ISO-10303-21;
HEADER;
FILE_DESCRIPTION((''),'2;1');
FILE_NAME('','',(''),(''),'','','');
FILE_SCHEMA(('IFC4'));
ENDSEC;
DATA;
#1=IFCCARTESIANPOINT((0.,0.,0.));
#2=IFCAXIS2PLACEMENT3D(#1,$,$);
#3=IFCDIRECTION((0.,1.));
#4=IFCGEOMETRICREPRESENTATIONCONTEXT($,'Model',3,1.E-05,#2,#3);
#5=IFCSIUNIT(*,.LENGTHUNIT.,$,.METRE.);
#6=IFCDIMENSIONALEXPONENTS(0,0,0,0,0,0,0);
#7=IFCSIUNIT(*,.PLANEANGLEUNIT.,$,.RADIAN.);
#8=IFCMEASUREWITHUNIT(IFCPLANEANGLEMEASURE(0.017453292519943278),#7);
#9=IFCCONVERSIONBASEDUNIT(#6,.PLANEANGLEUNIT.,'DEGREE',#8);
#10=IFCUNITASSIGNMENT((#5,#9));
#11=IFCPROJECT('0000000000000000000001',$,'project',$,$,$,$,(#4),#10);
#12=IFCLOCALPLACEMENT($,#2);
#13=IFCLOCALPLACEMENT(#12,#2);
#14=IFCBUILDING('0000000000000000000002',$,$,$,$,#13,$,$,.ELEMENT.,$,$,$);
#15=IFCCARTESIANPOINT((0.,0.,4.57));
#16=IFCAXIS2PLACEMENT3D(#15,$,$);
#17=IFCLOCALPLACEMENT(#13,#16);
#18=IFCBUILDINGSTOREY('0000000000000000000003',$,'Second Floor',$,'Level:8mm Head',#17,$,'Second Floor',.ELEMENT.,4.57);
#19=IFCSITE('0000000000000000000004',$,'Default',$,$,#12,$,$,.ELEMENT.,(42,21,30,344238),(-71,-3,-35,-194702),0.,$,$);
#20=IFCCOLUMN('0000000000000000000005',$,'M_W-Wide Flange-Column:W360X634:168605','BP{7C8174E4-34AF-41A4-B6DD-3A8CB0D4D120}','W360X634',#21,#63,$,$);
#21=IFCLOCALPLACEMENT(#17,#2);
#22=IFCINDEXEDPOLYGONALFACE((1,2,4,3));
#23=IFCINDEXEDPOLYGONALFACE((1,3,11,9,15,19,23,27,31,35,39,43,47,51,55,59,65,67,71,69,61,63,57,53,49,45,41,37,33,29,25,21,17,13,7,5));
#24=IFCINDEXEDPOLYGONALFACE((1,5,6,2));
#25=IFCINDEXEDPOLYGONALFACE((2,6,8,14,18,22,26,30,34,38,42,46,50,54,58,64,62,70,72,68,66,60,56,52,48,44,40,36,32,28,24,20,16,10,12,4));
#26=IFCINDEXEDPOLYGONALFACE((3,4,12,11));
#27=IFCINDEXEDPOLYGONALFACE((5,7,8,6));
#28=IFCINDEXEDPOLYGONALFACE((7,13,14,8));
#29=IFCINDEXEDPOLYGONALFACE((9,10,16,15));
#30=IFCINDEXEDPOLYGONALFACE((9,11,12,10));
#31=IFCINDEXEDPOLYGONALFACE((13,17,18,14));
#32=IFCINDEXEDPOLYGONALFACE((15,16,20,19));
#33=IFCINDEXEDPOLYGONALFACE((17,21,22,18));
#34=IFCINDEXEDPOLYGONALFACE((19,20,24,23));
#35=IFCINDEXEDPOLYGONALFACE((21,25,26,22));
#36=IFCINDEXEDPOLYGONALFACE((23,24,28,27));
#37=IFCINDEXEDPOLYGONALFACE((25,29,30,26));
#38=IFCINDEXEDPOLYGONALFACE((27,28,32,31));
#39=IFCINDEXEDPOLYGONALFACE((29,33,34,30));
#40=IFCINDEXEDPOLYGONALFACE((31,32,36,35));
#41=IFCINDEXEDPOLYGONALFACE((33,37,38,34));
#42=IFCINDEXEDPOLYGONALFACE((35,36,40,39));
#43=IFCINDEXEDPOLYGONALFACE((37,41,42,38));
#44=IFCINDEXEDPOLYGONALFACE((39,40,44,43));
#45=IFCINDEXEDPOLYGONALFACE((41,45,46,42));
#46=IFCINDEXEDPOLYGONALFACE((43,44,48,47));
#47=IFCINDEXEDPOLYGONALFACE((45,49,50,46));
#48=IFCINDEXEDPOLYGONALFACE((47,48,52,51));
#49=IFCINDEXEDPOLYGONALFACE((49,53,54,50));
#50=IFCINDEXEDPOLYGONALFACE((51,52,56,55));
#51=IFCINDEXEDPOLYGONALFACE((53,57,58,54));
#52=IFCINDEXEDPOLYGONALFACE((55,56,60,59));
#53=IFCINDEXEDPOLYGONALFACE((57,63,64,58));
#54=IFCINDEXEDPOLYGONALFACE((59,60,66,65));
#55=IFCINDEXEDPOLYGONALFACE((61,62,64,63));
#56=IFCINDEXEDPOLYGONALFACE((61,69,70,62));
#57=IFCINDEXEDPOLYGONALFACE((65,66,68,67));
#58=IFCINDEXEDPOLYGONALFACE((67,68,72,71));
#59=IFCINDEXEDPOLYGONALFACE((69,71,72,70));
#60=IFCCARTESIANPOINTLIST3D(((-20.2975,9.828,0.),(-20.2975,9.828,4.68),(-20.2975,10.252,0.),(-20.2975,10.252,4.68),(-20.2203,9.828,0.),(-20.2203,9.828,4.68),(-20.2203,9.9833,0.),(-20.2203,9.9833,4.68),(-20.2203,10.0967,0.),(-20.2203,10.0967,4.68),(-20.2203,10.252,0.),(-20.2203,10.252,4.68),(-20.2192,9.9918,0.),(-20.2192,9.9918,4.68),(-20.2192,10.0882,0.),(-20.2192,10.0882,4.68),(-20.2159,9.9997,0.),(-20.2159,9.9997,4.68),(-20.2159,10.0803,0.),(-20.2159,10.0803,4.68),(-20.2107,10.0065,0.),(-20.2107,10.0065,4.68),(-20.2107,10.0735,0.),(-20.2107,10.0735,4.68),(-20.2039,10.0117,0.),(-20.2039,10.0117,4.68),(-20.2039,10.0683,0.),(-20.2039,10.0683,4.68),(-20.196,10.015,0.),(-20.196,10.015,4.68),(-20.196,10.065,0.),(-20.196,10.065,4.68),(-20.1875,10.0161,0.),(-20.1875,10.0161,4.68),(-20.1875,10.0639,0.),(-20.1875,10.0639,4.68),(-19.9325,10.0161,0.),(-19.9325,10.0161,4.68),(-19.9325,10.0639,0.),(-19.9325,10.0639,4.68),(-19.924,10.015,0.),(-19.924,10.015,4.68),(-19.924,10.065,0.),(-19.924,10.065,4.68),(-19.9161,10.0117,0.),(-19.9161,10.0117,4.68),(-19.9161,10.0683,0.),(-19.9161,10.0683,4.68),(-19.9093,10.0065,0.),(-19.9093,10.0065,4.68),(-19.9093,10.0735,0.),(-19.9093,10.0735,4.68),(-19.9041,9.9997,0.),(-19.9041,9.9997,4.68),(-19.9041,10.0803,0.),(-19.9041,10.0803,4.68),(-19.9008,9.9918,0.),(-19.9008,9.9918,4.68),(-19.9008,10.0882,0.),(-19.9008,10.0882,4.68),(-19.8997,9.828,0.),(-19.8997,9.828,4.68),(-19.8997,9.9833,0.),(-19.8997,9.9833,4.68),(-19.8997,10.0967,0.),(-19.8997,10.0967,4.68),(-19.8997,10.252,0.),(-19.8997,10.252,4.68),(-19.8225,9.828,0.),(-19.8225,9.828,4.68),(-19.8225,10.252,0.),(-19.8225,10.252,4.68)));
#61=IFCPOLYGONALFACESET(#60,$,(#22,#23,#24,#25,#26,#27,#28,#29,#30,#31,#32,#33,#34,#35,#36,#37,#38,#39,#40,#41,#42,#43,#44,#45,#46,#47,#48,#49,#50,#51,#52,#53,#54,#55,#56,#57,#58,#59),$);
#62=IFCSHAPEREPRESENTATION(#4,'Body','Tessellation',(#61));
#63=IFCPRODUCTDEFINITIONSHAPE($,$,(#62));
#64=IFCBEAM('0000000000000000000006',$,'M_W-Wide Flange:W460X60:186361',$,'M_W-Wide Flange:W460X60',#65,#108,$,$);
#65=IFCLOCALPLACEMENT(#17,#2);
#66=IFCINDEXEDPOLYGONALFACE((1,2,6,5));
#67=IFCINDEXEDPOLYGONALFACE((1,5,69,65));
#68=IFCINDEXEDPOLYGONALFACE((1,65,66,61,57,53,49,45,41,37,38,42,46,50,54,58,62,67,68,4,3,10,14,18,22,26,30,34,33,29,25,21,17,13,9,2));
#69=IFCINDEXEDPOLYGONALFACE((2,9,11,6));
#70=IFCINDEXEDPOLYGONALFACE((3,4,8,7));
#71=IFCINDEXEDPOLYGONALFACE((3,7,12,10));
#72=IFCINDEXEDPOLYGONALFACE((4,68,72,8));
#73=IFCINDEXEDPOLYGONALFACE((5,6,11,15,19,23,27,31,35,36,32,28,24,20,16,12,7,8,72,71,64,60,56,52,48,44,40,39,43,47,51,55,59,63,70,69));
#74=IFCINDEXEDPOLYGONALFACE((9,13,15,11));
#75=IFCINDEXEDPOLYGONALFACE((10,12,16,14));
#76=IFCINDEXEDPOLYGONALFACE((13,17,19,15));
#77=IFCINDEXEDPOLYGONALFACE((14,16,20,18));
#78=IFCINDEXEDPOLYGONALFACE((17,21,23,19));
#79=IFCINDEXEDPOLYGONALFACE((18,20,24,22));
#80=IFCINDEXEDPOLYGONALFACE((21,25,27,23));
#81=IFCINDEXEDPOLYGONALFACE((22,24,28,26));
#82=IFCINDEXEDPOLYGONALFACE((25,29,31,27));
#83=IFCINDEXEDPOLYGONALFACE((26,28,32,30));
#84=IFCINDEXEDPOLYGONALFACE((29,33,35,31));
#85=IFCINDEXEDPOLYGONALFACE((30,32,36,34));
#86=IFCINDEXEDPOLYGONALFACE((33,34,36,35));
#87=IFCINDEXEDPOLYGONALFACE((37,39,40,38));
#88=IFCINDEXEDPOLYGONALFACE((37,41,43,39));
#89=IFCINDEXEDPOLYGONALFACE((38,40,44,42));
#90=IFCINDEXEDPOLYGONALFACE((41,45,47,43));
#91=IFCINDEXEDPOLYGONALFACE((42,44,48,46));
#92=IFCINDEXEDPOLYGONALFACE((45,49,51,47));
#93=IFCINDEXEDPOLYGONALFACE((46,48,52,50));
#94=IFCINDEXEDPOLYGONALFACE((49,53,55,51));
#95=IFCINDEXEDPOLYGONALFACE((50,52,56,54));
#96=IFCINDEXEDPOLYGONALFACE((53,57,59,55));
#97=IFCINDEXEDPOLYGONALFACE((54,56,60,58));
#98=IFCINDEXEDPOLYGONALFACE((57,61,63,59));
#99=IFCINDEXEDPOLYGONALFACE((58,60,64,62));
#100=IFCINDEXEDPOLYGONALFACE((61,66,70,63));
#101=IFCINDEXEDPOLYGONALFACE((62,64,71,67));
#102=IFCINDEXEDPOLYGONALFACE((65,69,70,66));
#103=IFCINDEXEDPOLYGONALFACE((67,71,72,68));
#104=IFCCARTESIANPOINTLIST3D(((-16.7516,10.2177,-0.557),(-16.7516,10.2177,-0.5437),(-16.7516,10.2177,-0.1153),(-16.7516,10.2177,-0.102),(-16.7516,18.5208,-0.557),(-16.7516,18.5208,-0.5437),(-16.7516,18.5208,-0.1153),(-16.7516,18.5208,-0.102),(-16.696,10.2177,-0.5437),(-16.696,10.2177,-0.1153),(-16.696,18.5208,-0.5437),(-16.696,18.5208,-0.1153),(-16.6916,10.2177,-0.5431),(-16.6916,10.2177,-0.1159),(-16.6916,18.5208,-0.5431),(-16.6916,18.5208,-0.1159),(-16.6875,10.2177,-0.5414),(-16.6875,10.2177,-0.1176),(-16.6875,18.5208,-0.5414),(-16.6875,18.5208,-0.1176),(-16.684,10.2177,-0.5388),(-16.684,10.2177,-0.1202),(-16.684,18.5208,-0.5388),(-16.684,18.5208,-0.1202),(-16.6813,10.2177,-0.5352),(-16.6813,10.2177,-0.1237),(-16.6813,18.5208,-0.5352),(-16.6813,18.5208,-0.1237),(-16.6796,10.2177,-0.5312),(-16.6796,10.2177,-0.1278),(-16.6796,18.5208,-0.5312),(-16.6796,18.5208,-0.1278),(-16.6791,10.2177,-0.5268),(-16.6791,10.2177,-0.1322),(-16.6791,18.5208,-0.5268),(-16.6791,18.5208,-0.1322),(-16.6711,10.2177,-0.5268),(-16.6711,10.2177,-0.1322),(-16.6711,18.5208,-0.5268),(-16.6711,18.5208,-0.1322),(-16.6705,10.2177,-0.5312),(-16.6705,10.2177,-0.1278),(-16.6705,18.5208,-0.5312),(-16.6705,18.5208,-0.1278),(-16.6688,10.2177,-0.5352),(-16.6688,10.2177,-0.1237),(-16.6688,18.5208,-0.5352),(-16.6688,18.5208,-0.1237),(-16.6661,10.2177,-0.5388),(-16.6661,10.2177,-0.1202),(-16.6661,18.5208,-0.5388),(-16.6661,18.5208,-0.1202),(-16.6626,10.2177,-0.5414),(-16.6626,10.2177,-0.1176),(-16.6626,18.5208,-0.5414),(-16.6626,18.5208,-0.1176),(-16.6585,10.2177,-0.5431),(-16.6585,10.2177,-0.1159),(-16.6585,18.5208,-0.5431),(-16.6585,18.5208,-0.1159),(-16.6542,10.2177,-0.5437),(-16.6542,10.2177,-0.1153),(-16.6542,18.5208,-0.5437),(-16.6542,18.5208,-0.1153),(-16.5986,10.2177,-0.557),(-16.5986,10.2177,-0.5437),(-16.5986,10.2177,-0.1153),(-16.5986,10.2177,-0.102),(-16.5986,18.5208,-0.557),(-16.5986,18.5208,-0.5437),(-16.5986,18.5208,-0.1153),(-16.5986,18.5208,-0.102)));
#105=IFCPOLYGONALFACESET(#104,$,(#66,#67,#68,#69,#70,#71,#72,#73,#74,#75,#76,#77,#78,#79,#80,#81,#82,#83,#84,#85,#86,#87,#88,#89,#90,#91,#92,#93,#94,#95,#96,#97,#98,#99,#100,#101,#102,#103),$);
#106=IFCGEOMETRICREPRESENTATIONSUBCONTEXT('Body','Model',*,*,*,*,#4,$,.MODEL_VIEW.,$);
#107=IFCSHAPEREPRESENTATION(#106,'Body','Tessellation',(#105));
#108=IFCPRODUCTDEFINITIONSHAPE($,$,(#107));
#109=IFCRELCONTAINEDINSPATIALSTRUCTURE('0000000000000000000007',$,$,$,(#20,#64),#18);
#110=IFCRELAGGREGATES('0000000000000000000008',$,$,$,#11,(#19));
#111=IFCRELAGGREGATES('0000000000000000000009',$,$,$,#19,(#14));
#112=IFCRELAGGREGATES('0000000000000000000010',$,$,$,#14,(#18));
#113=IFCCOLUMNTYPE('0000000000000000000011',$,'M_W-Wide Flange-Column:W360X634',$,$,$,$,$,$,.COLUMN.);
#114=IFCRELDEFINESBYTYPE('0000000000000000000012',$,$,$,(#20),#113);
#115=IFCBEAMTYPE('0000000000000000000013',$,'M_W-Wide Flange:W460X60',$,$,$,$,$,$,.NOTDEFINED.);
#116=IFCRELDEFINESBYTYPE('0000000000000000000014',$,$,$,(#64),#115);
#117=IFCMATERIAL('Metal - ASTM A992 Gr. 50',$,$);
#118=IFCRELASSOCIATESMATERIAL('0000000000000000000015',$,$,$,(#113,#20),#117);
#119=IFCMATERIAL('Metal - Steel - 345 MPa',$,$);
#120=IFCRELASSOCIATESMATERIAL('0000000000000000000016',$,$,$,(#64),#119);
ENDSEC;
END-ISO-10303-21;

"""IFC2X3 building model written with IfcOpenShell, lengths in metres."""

from ifc_helpers import new_model, entity, si_unit, converted_unit, direction, frame, frame_2d, origin, origin_2d, place, context, subcontext, project, spatial, i_section, extrude, material, type_object, element, save


model = new_model("IFC2X3")

# Units and contexts
model_context = context("Model", 3, precision=1e-05, world=origin(), true_north=direction((0.0, 1.0)))
body_context = subcontext(model_context, "Body", "Model", "MODEL_VIEW")
ifc_project = project(units=[si_unit("LENGTHUNIT", "METRE"), converted_unit("PLANEANGLEUNIT", "DEGREE", entity("IfcPlaneAngleMeasure", 0.017453292519943278), si_unit("PLANEANGLEUNIT", "RADIAN"), dimensions=[0, 0, 0, 0, 0, 0, 0])], contexts=[model_context])

# Site, building, storey
site_placement = place(None, origin())
site = spatial("IfcSite", under=ifc_project, at=site_placement, Name="Default", CompositionType="ELEMENT", RefLatitude=(42, 21, 30, 344238), RefLongitude=(-71, -3, -35, -194702), RefElevation=0.0)
building_placement = place(site_placement, origin())
building = spatial("IfcBuilding", under=site, at=building_placement, CompositionType="ELEMENT")
storey_placement = place(building_placement, frame((0.0, 0.0, 4.57)))
storey = spatial("IfcBuildingStorey", under=building, at=storey_placement, Name="Second Floor", ObjectType="Level:8mm Head", LongName="Second Floor", CompositionType="ELEMENT", Elevation=4.57)

# Column
ifc_material_1 = material(Name="Metal - ASTM A992 Gr. 50")
column_type = type_object("IfcColumnType", Name="M_W-Wide Flange-Column:W360X634", PredefinedType="COLUMN", material=ifc_material_1)
column_placement = place(storey_placement, frame((-20.06, 10.04, 4.68), z_axis=(0.0, 0.0, 1.0), x_axis=(0.0, -1.0, 0.0)))
element("IfcColumn", 1, at=column_placement, inside=storey, type_object=column_type, material=ifc_material_1, Name="M_W-Wide Flange-Column:W360X634:168605", Description="BP{7C8174E4-34AF-41A4-B6DD-3A8CB0D4D120}", ObjectType="W360X634", context=model_context, shape_type="SweptSolid", body=[
    extrude(i_section(OverallWidth=0.424, OverallDepth=0.475, WebThickness=0.0478, FlangeThickness=0.0772, FilletRadius=0.0328, at=origin_2d()), origin(), (0.0, 0.0, -1.0), 4.68),
])

# Beam
ifc_material_2 = material(Name="Metal - Steel - 345 MPa")
beam_type_1 = type_object("IfcBeamType", Name="M_W-Wide Flange:W460X60", PredefinedType="NOTDEFINED")
beam_1_placement = place(storey_placement, frame((-16.6751, 10.04, -0.102), z_axis=(0.0, 0.0, 1.0), x_axis=(0.0, 1.0, 0.0)))
element("IfcBeam", 2, at=beam_1_placement, inside=storey, type_object=beam_type_1, material=ifc_material_2, Name="M_W-Wide Flange:W460X60:186361", ObjectType="M_W-Wide Flange:W460X60", context=body_context, shape_type="SweptSolid", body=[
    extrude(i_section(OverallWidth=0.153, OverallDepth=0.455, WebThickness=0.008, FlangeThickness=0.0133, FilletRadius=0.0169, at=frame_2d((0.0, 0.0), x_axis=(0.0, 1.0))), frame((0.1777, 0.0, -0.2275), z_axis=(1.0, 0.0, 0.0), x_axis=(0.0, 0.0, -1.0)), (0.0, 0.0, 1.0), 8.3031),
])

save(model, "model.ifc")
